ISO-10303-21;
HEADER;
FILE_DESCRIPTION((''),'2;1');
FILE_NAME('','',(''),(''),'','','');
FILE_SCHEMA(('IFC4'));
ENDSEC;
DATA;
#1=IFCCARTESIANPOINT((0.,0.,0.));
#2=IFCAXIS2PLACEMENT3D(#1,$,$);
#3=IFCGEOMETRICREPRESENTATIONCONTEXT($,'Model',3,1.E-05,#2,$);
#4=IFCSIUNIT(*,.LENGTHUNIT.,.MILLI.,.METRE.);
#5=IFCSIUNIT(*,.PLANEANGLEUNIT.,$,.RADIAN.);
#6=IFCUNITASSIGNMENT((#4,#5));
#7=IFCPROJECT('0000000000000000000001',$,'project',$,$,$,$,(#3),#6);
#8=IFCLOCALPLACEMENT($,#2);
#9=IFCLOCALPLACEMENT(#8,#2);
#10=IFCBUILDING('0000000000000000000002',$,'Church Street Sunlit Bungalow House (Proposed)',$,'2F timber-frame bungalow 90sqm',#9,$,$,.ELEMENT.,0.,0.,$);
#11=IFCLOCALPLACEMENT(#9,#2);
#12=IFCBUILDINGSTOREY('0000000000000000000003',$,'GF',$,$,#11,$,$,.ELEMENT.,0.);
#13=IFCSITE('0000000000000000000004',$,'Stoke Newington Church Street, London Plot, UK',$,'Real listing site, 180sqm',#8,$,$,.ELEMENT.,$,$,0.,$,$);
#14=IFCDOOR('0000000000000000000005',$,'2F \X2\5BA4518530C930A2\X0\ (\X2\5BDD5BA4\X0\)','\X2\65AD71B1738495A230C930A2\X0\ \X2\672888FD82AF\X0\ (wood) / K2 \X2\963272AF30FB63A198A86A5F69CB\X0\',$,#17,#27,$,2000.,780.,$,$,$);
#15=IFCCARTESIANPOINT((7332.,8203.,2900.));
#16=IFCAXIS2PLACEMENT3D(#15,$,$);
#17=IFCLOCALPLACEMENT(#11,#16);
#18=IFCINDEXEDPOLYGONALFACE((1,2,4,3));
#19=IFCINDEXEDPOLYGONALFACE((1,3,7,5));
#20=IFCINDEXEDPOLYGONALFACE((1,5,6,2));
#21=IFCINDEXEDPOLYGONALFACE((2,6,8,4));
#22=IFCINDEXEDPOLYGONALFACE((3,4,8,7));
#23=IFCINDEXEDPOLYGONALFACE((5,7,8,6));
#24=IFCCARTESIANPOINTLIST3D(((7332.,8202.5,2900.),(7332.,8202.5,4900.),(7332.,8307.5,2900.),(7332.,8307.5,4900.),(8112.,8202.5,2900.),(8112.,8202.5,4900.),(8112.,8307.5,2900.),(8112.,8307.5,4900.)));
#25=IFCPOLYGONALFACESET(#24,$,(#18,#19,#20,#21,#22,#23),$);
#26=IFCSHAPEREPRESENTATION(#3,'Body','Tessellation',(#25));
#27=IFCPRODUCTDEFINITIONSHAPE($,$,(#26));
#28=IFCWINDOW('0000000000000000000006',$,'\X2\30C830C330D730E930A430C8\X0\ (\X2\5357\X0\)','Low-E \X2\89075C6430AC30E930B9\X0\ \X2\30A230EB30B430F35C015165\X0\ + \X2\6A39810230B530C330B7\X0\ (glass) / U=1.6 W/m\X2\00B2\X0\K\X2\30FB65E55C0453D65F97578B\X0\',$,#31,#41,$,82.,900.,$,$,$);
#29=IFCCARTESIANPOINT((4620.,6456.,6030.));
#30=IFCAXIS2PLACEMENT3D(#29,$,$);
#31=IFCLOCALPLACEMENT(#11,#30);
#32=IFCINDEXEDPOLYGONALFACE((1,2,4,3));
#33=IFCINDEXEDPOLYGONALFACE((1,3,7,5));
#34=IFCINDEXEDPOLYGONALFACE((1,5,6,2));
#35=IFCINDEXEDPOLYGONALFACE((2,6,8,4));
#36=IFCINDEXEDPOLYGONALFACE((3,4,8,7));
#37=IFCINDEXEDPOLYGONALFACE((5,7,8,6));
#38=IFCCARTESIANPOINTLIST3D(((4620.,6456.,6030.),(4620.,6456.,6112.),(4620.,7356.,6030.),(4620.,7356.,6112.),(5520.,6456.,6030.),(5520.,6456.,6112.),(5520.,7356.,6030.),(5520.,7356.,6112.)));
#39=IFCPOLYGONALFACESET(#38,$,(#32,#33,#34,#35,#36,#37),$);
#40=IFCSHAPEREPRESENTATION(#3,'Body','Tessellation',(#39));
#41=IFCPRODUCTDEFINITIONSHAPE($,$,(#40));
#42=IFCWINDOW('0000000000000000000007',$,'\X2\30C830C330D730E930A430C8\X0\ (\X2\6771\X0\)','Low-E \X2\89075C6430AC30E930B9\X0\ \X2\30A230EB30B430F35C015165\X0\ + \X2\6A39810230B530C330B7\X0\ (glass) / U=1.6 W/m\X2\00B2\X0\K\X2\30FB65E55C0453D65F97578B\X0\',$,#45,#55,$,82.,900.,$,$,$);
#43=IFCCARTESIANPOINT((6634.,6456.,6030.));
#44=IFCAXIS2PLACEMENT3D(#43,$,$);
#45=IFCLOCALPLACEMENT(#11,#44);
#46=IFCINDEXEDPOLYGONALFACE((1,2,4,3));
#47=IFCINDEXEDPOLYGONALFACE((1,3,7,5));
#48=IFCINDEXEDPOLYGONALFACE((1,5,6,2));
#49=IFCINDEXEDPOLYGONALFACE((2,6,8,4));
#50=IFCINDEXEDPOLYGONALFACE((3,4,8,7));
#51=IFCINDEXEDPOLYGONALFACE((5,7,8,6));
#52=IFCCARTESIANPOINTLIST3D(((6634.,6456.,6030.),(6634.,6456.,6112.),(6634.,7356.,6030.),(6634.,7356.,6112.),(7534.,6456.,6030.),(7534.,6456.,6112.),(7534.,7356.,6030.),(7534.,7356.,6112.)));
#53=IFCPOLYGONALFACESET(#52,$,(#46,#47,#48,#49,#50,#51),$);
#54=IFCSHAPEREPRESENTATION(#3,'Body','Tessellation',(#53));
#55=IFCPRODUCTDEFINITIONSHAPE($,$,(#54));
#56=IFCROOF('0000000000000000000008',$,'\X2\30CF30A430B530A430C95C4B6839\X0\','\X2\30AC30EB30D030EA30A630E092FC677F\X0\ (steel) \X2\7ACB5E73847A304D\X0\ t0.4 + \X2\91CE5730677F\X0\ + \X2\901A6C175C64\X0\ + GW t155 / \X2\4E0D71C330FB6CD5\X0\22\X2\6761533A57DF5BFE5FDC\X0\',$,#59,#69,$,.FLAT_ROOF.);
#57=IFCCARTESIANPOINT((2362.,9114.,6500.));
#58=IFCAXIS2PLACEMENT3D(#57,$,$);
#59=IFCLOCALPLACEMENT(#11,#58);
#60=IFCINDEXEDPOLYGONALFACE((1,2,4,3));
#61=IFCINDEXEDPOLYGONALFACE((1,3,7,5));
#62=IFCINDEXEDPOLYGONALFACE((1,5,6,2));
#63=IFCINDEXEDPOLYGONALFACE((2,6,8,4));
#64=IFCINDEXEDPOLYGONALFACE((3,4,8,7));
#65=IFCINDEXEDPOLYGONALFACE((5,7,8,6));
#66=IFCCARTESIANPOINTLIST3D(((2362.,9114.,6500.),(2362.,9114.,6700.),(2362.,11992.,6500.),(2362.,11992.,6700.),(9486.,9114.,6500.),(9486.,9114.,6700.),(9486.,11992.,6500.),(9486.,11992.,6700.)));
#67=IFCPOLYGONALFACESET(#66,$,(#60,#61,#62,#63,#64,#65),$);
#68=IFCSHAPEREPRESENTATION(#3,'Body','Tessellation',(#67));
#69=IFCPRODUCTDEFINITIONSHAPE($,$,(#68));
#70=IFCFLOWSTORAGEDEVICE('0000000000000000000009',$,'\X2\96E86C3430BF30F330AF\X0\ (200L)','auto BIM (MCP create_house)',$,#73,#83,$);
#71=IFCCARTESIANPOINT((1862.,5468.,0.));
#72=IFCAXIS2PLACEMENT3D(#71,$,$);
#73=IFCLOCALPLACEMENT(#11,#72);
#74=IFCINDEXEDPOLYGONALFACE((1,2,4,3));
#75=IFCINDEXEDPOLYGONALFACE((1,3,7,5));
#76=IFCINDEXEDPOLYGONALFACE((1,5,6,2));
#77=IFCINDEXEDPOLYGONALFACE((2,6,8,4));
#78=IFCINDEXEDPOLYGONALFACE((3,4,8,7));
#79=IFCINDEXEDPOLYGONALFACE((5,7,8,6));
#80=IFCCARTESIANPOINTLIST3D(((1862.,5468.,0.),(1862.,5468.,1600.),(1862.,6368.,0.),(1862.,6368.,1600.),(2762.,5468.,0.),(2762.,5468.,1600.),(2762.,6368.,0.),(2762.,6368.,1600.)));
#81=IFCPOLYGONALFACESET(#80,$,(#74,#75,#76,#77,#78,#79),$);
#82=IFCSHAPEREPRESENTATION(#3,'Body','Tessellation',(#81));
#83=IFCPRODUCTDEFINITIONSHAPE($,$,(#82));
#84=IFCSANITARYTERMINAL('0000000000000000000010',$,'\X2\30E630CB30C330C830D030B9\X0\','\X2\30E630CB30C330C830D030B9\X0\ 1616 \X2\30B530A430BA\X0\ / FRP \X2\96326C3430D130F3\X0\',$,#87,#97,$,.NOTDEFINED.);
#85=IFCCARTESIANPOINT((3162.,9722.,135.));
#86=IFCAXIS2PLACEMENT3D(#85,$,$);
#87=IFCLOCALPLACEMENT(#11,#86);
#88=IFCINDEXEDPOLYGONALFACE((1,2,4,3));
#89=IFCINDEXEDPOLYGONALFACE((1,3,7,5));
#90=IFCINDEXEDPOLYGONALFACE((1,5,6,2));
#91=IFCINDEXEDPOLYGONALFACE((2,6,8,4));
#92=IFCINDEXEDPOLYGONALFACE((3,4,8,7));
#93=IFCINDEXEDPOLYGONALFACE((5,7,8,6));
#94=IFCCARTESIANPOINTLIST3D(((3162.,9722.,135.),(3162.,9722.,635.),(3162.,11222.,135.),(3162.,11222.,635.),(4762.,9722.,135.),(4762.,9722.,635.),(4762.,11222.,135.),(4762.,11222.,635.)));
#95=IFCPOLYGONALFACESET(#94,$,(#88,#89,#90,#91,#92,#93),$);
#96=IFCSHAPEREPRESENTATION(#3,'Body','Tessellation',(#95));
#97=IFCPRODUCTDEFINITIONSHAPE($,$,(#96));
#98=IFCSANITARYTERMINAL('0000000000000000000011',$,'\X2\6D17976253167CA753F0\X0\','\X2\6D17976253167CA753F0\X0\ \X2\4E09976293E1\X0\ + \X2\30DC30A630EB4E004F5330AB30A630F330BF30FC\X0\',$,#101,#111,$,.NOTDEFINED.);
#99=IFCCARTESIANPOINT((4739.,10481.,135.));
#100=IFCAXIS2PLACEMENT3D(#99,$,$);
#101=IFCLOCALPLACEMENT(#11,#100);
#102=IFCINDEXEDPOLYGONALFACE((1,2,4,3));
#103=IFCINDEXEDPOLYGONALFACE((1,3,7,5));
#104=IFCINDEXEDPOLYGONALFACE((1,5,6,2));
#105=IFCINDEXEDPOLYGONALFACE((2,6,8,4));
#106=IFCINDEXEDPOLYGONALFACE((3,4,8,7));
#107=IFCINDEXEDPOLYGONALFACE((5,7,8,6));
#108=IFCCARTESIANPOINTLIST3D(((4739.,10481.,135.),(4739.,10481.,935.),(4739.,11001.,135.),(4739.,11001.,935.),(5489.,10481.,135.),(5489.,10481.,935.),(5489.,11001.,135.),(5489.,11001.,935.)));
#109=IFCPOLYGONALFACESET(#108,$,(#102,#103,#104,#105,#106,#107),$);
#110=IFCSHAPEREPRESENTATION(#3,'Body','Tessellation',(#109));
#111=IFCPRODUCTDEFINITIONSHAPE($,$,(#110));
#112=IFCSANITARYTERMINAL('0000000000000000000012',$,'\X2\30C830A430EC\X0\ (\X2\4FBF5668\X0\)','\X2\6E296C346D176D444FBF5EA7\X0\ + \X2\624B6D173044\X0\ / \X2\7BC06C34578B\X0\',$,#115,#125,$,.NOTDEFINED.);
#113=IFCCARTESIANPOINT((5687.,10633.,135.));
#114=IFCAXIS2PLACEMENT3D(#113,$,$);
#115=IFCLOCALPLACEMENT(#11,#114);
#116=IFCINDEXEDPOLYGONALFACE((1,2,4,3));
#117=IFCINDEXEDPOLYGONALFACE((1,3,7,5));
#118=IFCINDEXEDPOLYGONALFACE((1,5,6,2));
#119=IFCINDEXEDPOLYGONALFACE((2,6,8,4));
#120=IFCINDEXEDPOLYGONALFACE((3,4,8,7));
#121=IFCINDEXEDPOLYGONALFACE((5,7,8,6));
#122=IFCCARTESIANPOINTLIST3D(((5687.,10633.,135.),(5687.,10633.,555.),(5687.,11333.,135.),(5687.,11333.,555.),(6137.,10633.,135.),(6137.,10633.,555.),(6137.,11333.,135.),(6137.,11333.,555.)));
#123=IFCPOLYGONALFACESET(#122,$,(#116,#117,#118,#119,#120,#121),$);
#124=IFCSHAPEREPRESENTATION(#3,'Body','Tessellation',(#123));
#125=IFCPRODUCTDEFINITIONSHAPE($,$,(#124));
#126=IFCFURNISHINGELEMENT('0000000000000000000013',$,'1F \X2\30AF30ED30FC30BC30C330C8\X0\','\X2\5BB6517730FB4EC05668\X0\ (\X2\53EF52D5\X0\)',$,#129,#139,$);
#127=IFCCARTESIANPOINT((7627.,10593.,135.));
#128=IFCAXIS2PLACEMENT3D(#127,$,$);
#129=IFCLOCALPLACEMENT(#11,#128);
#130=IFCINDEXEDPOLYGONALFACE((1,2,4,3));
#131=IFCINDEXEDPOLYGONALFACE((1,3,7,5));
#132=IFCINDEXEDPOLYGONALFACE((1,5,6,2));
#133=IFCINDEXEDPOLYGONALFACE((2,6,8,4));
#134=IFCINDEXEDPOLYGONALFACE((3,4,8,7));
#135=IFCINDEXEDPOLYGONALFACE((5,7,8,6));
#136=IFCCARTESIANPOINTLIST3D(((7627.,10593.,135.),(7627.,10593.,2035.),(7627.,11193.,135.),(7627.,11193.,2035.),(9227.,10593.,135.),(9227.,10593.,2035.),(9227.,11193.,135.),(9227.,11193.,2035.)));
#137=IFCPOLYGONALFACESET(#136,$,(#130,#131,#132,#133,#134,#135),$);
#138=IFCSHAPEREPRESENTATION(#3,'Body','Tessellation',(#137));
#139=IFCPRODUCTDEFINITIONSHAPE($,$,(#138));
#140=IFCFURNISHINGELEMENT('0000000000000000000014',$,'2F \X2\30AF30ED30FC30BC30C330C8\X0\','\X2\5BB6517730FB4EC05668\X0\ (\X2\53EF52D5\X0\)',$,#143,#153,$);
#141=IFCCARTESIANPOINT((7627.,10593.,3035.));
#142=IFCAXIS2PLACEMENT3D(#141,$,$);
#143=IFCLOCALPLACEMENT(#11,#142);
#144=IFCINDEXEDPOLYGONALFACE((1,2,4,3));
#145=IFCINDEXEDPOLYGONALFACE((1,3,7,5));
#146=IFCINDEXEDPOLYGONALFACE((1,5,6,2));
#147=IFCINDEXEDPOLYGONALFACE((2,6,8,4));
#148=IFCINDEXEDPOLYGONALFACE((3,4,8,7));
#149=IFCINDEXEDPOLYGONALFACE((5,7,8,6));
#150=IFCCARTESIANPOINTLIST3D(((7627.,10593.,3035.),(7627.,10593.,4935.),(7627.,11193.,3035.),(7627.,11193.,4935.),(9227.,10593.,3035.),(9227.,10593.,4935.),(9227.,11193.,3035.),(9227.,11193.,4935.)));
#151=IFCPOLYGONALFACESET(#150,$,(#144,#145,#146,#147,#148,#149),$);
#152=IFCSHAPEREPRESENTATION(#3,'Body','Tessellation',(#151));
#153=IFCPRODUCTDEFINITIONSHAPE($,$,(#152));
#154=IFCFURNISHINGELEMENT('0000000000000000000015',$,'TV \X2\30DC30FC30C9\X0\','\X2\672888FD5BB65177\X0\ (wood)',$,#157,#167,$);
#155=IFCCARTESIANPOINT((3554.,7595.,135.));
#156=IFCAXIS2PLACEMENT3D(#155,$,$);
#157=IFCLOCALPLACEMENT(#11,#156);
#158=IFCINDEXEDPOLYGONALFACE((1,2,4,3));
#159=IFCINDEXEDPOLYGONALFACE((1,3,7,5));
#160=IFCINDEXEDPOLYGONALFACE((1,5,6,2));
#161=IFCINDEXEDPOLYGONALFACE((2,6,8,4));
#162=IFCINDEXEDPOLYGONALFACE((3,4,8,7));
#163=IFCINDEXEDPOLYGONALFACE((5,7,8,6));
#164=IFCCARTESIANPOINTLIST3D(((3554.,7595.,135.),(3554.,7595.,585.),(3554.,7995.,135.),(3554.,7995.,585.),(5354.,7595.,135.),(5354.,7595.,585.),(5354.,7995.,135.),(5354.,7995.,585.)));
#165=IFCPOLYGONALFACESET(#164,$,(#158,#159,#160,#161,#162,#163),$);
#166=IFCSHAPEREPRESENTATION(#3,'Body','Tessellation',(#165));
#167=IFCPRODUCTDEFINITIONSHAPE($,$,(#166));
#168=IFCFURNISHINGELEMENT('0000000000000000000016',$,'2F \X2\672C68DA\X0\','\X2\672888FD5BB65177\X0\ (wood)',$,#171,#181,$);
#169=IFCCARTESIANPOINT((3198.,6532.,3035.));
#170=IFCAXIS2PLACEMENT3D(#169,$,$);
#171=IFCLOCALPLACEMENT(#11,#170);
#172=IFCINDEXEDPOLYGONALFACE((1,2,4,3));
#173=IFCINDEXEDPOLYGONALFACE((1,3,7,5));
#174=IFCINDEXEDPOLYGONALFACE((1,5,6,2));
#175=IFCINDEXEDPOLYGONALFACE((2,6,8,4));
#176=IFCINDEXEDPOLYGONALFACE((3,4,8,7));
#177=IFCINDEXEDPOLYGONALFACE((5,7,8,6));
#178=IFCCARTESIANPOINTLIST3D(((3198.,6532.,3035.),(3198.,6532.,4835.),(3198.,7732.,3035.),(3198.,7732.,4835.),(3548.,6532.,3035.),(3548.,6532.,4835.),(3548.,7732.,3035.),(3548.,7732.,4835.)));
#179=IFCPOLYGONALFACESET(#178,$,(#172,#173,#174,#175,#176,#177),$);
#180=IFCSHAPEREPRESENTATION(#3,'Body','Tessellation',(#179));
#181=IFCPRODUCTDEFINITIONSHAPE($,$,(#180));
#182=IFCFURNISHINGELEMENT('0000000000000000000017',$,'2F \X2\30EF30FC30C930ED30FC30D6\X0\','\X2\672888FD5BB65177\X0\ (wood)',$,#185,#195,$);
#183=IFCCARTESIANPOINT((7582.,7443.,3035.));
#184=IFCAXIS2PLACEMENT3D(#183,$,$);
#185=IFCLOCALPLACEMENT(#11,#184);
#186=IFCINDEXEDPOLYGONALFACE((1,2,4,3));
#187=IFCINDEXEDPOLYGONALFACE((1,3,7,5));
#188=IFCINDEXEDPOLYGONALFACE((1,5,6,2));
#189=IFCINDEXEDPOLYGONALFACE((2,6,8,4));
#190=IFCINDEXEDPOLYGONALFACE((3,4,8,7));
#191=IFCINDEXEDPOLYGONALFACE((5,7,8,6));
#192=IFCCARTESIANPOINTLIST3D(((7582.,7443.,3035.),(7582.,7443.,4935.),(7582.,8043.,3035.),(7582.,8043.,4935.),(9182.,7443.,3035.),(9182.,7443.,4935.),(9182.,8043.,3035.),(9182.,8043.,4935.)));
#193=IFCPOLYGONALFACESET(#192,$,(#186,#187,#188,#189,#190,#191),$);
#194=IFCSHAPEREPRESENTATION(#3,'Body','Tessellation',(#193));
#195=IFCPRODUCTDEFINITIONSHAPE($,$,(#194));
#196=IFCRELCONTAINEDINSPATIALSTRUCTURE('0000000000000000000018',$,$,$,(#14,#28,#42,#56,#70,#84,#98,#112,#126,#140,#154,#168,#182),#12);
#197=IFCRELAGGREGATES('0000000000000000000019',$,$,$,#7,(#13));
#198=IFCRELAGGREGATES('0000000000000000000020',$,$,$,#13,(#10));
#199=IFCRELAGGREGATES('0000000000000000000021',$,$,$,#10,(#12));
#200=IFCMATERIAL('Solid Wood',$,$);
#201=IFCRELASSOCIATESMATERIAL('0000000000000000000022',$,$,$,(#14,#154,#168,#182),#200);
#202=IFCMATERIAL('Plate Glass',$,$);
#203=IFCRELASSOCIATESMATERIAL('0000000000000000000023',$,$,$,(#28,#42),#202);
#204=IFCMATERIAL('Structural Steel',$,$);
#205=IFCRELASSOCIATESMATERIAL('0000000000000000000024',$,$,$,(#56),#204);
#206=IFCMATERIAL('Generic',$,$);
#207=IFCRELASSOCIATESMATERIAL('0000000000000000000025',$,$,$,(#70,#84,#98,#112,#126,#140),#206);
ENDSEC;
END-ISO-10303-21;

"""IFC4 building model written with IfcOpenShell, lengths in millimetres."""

from ifc_helpers import new_model, si_unit, frame, frame_2d, origin, place, context, project, spatial, rectangle, extrude, material, element, save


model = new_model("IFC4")

# Units and contexts
model_context = context("Model", 3, precision=1e-05, world=origin())
ifc_project = project(units=[si_unit("LENGTHUNIT", "METRE", prefix="MILLI"), si_unit("PLANEANGLEUNIT", "RADIAN")], contexts=[model_context])

# Site, building, storey
site_placement = place(None, origin())
site = spatial("IfcSite", under=ifc_project, at=site_placement, Name="Stoke Newington Church Street, London Plot, UK", ObjectType="Real listing site, 180sqm", CompositionType="ELEMENT", RefElevation=0.0)
building_placement = place(site_placement, origin())
building = spatial("IfcBuilding", under=site, at=building_placement, Name="Church Street Sunlit Bungalow House (Proposed)", ObjectType="2F timber-frame bungalow 90sqm", CompositionType="ELEMENT", ElevationOfRefHeight=0.0, ElevationOfTerrain=0.0)
storey_placement = place(building_placement, origin())
storey = spatial("IfcBuildingStorey", under=building, at=storey_placement, Name="GF", CompositionType="ELEMENT", Elevation=0.0)

# Shared definitions
ifc_material_1 = material(Name="Solid Wood")
ifc_material_2 = material(Name="Plate Glass")

# Door
door_1_placement = place(storey_placement, frame((7332.0, 8203.0, 2900.0)))
element("IfcDoor", 1, at=door_1_placement, inside=storey, material=ifc_material_1, Name="2F 室内ドア (寝室)", Description="断熱玄関ドア 木製芯 (wood) / K2 防犯・採風機構", OverallHeight=2000.0, OverallWidth=780.0, context=model_context, shape_type="SweptSolid", body=[
    extrude(rectangle(XDim=780.0, YDim=105.0, at=frame_2d((390.0, 52.0))), frame((7332.0, 8203.0, 2900.0)), (0.0, 0.0, 1.0), 2000.0),
])

# Windows
window_1_placement = place(storey_placement, frame((4620.0, 6456.0, 6030.0)))
element("IfcWindow", 2, at=window_1_placement, inside=storey, material=ifc_material_2, Name="トップライト (南)", Description="Low-E 複層ガラス アルゴン封入 + 樹脂サッシ (glass) / U=1.6 W/m²K・日射取得型", OverallHeight=82.0, OverallWidth=900.0, context=model_context, shape_type="SweptSolid", body=[
    extrude(rectangle(XDim=900.0, YDim=900.0, at=frame_2d((450.0, 450.0))), frame((4620.0, 6456.0, 6030.0)), (0.0, 0.0, 1.0), 82.0),
])
window_2_placement = place(storey_placement, frame((6634.0, 6456.0, 6030.0)))
element("IfcWindow", 3, at=window_2_placement, inside=storey, material=ifc_material_2, Name="トップライト (東)", Description="Low-E 複層ガラス アルゴン封入 + 樹脂サッシ (glass) / U=1.6 W/m²K・日射取得型", OverallHeight=82.0, OverallWidth=900.0, context=model_context, shape_type="SweptSolid", body=[
    extrude(rectangle(XDim=900.0, YDim=900.0, at=frame_2d((450.0, 450.0))), frame((6634.0, 6456.0, 6030.0)), (0.0, 0.0, 1.0), 82.0),
])

# Roof
ifc_material_3 = material(Name="Structural Steel")
roof_placement = place(storey_placement, frame((2362.0, 9114.0, 6500.0)))
element("IfcRoof", 4, at=roof_placement, inside=storey, material=ifc_material_3, Name="ハイサイド屋根", Description="ガルバリウム鋼板 (steel) 立平葺き t0.4 + 野地板 + 通気層 + GW t155 / 不燃・法22条区域対応", PredefinedType="FLAT_ROOF", context=model_context, shape_type="SweptSolid", body=[
    extrude(rectangle(XDim=7124.0, YDim=2878.0, at=frame_2d((3562.0, 1439.0))), frame((2362.0, 9114.0, 6500.0)), (0.0, 0.0, 1.0), 200.0),
])

# Flow storage device
ifc_material_4 = material(Name="Generic")
flow_storage_device_placement = place(storey_placement, frame((1862.0, 5468.0, 0.0)))
element("IfcFlowStorageDevice", 5, at=flow_storage_device_placement, inside=storey, material=ifc_material_4, Name="雨水タンク (200L)", Description="auto BIM (MCP create_house)", context=model_context, shape_type="SweptSolid", body=[
    extrude(rectangle(XDim=900.0, YDim=900.0, at=frame_2d((450.0, 450.0))), frame((1862.0, 5468.0, 0.0)), (0.0, 0.0, 1.0), 1600.0),
])

# Sanitary terminals
sanitary_terminal_1_placement = place(storey_placement, frame((3162.0, 9722.0, 135.0)))
element("IfcSanitaryTerminal", 6, at=sanitary_terminal_1_placement, inside=storey, material=ifc_material_4, Name="ユニットバス", Description="ユニットバス 1616 サイズ / FRP 防水パン", PredefinedType="NOTDEFINED", context=model_context, shape_type="SweptSolid", body=[
    extrude(rectangle(XDim=1600.0, YDim=1500.0, at=frame_2d((800.0, 750.0))), frame((3162.0, 9722.0, 135.0)), (0.0, 0.0, 1.0), 500.0),
])
sanitary_terminal_2_placement = place(storey_placement, frame((4739.0, 10481.0, 135.0)))
element("IfcSanitaryTerminal", 7, at=sanitary_terminal_2_placement, inside=storey, material=ifc_material_4, Name="洗面化粧台", Description="洗面化粧台 三面鏡 + ボウル一体カウンター", PredefinedType="NOTDEFINED", context=model_context, shape_type="SweptSolid", body=[
    extrude(rectangle(XDim=750.0, YDim=520.0, at=frame_2d((375.0, 260.0))), frame((4739.0, 10481.0, 135.0)), (0.0, 0.0, 1.0), 800.0),
])
sanitary_terminal_3_placement = place(storey_placement, frame((5687.0, 10633.0, 135.0)))
element("IfcSanitaryTerminal", 8, at=sanitary_terminal_3_placement, inside=storey, material=ifc_material_4, Name="トイレ (便器)", Description="温水洗浄便座 + 手洗い / 節水型", PredefinedType="NOTDEFINED", context=model_context, shape_type="SweptSolid", body=[
    extrude(rectangle(XDim=450.0, YDim=700.0, at=frame_2d((225.0, 350.0))), frame((5687.0, 10633.0, 135.0)), (0.0, 0.0, 1.0), 420.0),
])

# Furnishing elements
furnishing_1_placement = place(storey_placement, frame((7627.0, 10593.0, 135.0)))
element("IfcFurnishingElement", 9, at=furnishing_1_placement, inside=storey, material=ifc_material_4, Name="1F クローゼット", Description="家具・什器 (可動)", context=model_context, shape_type="SweptSolid", body=[
    extrude(rectangle(XDim=1600.0, YDim=600.0, at=frame_2d((800.0, 300.0))), frame((7627.0, 10593.0, 135.0)), (0.0, 0.0, 1.0), 1900.0),
])
furnishing_2_placement = place(storey_placement, frame((7627.0, 10593.0, 3035.0)))
element("IfcFurnishingElement", 10, at=furnishing_2_placement, inside=storey, material=ifc_material_4, Name="2F クローゼット", Description="家具・什器 (可動)", context=model_context, shape_type="SweptSolid", body=[
    extrude(rectangle(XDim=1600.0, YDim=600.0, at=frame_2d((800.0, 300.0))), frame((7627.0, 10593.0, 3035.0)), (0.0, 0.0, 1.0), 1900.0),
])
furnishing_3_placement = place(storey_placement, frame((3554.0, 7595.0, 135.0)))
element("IfcFurnishingElement", 11, at=furnishing_3_placement, inside=storey, material=ifc_material_1, Name="TV ボード", Description="木製家具 (wood)", context=model_context, shape_type="SweptSolid", body=[
    extrude(rectangle(XDim=1800.0, YDim=400.0, at=frame_2d((900.0, 200.0))), frame((3554.0, 7595.0, 135.0)), (0.0, 0.0, 1.0), 450.0),
])
furnishing_4_placement = place(storey_placement, frame((3198.0, 6532.0, 3035.0)))
element("IfcFurnishingElement", 12, at=furnishing_4_placement, inside=storey, material=ifc_material_1, Name="2F 本棚", Description="木製家具 (wood)", context=model_context, shape_type="SweptSolid", body=[
    extrude(rectangle(XDim=350.0, YDim=1200.0, at=frame_2d((175.0, 600.0))), frame((3198.0, 6532.0, 3035.0)), (0.0, 0.0, 1.0), 1800.0),
])
furnishing_5_placement = place(storey_placement, frame((7582.0, 7443.0, 3035.0)))
element("IfcFurnishingElement", 13, at=furnishing_5_placement, inside=storey, material=ifc_material_1, Name="2F ワードローブ", Description="木製家具 (wood)", context=model_context, shape_type="SweptSolid", body=[
    extrude(rectangle(XDim=1600.0, YDim=600.0, at=frame_2d((800.0, 300.0))), frame((7582.0, 7443.0, 3035.0)), (0.0, 0.0, 1.0), 1900.0),
])

save(model, "model.ifc")
